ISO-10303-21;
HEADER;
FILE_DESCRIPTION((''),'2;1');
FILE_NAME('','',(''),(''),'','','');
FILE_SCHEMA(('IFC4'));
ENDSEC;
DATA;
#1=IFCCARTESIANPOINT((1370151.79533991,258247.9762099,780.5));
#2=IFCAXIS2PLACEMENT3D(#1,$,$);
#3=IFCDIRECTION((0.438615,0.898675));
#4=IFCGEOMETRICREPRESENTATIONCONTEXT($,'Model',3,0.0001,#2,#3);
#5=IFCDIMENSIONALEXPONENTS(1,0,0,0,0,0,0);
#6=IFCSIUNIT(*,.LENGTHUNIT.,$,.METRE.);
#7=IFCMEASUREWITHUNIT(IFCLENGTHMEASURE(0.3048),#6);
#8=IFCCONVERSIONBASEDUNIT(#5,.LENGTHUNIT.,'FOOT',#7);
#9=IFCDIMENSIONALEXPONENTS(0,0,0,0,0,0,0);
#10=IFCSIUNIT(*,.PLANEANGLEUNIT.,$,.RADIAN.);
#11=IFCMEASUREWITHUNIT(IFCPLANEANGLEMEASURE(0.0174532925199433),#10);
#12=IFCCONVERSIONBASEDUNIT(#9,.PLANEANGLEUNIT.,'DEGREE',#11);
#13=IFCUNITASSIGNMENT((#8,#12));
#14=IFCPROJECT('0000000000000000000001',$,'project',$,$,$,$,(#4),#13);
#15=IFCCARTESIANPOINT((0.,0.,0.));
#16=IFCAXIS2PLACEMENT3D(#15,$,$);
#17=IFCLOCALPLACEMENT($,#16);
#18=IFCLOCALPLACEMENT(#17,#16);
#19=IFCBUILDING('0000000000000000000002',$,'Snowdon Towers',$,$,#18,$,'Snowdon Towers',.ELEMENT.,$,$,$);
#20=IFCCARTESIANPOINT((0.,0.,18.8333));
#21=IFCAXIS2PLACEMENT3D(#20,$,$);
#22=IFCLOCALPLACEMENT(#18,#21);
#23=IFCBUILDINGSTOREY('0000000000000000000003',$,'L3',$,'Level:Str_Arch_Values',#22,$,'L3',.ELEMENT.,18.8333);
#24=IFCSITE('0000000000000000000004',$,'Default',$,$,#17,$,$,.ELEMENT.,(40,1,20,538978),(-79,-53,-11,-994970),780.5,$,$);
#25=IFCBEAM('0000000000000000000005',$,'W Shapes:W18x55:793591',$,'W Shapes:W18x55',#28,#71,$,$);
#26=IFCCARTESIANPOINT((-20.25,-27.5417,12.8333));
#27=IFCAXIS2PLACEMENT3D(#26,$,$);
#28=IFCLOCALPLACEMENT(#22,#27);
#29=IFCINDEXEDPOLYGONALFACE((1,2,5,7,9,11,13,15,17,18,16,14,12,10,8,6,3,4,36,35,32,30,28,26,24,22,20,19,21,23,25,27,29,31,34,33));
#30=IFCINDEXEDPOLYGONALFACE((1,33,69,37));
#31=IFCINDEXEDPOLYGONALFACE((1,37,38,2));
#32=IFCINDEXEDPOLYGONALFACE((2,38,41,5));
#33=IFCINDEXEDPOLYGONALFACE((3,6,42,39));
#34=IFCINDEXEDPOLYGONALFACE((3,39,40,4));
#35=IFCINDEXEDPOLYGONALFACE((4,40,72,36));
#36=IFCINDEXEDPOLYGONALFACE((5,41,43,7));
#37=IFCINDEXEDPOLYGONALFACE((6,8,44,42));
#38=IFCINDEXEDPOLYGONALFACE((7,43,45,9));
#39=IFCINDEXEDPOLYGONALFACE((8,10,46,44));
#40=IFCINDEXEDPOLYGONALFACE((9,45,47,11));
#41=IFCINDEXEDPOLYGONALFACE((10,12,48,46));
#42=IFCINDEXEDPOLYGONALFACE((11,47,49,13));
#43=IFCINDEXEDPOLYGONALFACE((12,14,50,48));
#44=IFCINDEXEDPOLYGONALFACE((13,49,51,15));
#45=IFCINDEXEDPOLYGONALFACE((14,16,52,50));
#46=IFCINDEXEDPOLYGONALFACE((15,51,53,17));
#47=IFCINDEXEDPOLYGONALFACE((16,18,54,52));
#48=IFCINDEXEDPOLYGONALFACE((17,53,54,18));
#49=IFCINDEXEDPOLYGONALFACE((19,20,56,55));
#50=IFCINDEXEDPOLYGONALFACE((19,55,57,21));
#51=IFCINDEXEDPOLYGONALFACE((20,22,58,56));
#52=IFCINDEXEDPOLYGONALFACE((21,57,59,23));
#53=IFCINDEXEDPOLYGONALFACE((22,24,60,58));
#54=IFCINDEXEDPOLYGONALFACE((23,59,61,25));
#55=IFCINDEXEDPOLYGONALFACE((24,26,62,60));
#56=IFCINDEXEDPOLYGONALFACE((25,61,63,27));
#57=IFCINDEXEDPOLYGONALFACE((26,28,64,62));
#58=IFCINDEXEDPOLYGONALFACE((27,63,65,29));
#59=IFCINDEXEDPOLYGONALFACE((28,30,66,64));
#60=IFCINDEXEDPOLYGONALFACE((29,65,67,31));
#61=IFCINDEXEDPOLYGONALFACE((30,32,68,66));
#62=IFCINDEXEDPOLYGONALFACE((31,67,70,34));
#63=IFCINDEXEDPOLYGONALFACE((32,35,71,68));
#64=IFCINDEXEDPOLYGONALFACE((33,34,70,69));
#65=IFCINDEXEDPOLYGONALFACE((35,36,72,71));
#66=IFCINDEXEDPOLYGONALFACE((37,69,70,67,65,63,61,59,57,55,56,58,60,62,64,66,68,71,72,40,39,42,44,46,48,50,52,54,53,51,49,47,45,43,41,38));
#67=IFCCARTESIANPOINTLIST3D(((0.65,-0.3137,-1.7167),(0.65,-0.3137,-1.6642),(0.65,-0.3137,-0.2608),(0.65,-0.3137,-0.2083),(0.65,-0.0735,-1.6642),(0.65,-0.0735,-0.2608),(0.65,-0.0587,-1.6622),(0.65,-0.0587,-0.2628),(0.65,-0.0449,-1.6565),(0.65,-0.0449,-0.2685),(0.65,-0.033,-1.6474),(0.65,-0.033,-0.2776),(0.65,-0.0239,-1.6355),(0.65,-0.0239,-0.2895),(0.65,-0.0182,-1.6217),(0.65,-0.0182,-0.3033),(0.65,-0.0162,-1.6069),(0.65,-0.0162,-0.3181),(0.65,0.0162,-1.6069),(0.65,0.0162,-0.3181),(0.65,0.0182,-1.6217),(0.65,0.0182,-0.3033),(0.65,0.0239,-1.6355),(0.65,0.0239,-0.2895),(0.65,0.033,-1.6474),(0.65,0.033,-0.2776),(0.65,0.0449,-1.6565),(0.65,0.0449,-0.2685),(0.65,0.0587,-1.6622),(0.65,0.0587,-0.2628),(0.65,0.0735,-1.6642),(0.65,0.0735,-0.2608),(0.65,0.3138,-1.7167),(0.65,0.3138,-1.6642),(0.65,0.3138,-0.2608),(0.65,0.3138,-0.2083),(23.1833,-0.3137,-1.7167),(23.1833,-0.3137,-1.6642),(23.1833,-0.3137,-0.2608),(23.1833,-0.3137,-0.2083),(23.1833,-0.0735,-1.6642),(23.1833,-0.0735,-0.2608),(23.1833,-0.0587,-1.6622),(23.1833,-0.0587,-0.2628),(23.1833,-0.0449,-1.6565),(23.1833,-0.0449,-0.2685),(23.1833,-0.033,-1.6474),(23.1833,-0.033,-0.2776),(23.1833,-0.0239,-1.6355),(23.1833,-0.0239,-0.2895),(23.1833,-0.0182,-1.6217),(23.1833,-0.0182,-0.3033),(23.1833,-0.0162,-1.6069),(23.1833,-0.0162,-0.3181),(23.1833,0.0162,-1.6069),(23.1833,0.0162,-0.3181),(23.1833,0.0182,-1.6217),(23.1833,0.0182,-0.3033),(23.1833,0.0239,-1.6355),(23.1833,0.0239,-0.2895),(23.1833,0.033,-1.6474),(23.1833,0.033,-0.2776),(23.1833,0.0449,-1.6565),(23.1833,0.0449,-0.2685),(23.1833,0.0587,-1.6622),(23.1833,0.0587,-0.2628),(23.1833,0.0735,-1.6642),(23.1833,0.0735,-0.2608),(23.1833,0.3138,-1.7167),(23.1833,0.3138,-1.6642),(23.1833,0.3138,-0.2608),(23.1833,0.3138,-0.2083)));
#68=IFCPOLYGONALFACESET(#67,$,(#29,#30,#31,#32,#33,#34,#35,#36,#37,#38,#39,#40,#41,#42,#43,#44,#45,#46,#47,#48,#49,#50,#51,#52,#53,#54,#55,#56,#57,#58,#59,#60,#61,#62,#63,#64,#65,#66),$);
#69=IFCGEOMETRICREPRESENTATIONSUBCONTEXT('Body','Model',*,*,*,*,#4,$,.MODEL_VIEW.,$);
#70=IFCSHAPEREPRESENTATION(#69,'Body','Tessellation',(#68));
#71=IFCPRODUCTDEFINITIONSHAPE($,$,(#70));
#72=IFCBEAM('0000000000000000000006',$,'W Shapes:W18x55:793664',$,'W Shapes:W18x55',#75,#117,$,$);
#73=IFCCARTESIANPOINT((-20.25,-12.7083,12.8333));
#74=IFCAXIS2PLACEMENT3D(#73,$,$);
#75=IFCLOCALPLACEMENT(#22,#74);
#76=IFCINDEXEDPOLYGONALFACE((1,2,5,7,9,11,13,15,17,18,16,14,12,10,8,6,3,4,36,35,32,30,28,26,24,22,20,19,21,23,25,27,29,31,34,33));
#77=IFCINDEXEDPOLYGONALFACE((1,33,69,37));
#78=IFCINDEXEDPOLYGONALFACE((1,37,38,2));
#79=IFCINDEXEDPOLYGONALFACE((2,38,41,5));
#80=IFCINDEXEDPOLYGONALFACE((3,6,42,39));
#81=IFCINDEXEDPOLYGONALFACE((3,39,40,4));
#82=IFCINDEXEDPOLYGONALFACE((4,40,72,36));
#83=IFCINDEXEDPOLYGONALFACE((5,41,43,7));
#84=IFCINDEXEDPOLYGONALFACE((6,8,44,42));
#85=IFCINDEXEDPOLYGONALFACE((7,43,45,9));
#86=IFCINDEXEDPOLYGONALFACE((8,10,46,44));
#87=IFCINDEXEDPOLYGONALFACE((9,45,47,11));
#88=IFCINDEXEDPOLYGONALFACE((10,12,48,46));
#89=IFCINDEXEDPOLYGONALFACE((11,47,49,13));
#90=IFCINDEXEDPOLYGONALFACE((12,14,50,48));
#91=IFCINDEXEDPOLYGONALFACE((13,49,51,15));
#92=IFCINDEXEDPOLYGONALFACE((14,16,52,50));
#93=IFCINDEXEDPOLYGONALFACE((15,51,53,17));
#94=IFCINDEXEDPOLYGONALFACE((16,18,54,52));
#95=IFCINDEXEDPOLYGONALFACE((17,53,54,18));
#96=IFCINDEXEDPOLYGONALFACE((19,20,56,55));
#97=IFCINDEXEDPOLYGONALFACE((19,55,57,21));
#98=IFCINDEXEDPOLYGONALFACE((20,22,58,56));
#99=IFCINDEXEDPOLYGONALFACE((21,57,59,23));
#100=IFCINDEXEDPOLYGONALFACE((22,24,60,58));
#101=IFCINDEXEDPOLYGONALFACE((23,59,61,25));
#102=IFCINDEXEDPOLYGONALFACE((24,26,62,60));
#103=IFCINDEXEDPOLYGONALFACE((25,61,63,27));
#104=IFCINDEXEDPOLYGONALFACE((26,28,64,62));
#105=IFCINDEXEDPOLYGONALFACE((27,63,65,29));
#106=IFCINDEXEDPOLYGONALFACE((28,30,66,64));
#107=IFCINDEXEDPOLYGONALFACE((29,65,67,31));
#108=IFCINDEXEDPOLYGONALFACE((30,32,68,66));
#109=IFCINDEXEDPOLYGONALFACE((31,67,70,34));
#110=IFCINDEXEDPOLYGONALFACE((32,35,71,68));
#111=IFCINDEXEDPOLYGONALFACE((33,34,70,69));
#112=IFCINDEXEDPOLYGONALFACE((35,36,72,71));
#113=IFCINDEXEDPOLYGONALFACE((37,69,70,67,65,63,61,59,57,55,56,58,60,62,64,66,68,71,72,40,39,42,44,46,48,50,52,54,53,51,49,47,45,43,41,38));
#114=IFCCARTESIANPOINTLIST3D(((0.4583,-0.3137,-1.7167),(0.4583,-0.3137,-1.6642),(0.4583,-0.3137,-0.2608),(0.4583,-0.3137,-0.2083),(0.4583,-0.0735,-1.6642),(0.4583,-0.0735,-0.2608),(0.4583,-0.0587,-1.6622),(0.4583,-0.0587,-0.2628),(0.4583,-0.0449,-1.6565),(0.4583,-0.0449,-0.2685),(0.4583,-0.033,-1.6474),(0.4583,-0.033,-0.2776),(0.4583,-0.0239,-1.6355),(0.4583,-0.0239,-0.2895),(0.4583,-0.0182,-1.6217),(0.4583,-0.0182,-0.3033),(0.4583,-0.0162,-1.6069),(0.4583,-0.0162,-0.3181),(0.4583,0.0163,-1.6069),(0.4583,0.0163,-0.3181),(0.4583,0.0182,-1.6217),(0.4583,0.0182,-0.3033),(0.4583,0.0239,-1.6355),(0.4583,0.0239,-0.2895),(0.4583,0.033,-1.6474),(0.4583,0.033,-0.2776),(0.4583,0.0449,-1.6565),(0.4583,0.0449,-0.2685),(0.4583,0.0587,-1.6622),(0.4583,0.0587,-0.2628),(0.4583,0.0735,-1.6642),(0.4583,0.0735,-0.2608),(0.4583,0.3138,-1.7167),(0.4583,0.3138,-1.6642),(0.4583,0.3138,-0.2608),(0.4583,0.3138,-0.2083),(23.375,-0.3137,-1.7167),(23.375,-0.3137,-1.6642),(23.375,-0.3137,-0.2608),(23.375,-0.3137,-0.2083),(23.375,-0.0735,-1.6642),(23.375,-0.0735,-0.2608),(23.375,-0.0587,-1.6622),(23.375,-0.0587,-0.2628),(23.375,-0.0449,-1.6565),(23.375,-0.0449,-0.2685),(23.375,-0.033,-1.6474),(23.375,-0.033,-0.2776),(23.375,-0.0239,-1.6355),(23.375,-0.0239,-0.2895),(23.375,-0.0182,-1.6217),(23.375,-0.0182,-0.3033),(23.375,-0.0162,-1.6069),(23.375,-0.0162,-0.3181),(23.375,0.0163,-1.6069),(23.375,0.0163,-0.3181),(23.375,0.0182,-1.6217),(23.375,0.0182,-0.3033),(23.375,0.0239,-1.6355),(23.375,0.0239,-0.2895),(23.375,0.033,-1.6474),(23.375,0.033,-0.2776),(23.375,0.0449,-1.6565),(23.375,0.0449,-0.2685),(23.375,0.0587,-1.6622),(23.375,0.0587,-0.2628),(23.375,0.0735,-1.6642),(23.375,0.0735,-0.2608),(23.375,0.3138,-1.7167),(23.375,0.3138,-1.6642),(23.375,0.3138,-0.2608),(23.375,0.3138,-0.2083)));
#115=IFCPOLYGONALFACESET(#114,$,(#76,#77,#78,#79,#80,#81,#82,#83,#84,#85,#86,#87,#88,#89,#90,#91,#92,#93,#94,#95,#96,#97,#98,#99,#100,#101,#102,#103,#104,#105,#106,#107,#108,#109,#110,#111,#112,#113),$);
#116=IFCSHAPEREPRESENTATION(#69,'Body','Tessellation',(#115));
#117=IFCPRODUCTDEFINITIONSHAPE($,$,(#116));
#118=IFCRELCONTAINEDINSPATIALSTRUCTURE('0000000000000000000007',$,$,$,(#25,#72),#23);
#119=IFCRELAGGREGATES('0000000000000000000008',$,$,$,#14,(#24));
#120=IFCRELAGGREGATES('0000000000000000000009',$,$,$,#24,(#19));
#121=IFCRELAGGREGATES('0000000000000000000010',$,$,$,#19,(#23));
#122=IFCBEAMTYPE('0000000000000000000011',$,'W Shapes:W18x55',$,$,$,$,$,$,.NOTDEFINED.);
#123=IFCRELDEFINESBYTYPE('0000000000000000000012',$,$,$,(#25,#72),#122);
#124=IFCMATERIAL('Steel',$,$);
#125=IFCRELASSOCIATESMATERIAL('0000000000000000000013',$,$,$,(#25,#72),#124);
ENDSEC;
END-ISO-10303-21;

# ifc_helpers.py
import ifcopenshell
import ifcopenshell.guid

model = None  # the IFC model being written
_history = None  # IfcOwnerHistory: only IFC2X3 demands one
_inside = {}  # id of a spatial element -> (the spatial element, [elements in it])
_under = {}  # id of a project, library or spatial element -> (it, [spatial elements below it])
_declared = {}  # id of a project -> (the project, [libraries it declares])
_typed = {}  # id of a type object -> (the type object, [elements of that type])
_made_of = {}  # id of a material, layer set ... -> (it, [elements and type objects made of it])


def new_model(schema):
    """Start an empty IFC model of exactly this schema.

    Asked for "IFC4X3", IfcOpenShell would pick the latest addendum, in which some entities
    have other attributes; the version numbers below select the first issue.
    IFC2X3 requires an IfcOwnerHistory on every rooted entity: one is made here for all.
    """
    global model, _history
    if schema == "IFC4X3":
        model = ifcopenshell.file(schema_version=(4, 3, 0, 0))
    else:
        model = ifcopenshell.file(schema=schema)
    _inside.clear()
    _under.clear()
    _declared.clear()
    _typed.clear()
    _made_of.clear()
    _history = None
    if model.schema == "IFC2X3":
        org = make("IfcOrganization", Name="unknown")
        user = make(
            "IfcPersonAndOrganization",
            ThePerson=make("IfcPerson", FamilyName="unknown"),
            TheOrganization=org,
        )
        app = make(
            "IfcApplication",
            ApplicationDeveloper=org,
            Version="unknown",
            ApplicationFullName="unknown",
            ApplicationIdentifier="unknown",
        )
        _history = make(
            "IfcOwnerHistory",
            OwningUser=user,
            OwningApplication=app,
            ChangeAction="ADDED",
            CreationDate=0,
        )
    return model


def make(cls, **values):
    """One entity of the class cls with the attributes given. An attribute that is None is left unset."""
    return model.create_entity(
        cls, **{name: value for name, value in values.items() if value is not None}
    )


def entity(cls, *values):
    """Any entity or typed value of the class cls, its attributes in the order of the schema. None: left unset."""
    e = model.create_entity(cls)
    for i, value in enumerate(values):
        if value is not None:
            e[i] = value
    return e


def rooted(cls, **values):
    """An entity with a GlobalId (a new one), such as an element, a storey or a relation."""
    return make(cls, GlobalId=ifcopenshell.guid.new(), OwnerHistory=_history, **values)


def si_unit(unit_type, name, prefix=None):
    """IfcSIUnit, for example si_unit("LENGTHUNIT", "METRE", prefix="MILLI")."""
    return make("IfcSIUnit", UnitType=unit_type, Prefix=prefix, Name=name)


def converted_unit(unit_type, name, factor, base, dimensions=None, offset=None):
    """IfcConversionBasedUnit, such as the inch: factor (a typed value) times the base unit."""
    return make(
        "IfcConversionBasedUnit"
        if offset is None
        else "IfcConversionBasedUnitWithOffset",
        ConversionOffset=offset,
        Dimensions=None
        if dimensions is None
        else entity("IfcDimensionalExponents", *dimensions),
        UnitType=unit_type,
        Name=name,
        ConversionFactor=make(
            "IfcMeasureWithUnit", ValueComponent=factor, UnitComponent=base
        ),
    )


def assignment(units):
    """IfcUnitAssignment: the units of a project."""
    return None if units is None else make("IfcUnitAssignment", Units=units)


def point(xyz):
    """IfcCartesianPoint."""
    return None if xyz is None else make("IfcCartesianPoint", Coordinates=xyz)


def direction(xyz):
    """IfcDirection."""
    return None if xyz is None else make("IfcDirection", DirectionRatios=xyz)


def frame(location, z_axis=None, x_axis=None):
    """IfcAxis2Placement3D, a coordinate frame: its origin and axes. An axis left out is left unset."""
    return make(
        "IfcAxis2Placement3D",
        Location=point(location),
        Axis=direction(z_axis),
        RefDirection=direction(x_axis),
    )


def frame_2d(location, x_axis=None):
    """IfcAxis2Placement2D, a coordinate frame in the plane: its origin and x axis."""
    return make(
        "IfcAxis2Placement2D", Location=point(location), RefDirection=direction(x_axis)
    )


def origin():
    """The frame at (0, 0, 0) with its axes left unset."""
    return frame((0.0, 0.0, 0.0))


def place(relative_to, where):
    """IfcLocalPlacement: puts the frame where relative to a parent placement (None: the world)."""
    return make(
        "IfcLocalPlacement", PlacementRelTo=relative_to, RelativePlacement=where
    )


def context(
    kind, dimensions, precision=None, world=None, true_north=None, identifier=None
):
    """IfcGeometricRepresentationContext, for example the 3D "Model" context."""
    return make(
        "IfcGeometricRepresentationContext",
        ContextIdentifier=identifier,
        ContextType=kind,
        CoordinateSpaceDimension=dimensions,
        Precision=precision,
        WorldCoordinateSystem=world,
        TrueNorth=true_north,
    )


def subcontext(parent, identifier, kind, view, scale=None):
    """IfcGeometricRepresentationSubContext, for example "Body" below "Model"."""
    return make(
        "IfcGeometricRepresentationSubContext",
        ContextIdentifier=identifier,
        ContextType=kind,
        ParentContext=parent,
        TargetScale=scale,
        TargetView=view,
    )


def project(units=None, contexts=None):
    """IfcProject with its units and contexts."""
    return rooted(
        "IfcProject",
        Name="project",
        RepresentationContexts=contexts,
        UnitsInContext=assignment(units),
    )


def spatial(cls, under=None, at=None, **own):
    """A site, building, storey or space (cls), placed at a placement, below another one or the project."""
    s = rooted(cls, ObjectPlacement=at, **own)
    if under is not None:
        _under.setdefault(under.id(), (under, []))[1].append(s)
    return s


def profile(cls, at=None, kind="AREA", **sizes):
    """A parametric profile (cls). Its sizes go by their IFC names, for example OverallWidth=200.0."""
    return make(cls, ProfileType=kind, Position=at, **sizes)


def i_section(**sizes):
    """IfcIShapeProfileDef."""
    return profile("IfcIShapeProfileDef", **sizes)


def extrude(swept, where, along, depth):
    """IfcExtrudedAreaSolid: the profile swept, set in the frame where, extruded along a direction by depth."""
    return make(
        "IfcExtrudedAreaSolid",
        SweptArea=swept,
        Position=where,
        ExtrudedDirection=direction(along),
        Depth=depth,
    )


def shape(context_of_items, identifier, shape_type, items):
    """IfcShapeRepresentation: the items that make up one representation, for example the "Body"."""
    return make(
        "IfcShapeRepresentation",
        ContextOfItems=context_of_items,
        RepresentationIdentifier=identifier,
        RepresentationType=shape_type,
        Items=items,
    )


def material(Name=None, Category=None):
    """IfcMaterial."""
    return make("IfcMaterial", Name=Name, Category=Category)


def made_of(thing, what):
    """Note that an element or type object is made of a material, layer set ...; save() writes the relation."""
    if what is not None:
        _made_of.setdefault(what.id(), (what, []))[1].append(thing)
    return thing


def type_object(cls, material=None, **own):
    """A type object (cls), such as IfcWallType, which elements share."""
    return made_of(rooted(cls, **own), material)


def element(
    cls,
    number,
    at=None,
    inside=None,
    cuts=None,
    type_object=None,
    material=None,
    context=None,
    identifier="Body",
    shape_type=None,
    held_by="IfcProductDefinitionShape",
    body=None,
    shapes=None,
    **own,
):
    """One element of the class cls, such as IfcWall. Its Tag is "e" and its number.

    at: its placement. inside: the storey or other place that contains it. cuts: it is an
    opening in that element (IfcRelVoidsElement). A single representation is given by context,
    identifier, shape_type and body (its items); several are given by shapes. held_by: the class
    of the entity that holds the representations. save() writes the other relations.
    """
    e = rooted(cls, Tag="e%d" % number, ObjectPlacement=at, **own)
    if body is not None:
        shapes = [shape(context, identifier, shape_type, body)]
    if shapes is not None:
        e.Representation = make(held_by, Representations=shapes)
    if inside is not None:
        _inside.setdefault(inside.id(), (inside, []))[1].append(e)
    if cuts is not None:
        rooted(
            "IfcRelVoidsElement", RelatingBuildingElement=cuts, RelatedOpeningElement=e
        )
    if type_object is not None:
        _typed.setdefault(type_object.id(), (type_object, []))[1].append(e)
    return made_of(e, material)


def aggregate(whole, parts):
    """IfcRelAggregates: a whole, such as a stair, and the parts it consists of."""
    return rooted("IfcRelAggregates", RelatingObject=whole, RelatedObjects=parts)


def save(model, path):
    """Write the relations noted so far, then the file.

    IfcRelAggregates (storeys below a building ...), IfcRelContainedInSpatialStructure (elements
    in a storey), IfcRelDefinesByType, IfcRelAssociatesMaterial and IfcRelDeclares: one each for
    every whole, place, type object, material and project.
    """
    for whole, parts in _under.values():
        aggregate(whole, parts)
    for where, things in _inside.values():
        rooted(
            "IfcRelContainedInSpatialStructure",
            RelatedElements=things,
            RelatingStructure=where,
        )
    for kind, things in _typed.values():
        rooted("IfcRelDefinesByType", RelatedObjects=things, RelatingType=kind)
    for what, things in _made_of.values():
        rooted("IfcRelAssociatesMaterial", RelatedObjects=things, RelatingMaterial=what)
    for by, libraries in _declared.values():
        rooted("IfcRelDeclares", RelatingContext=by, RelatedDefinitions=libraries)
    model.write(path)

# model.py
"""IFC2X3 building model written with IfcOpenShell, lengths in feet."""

from ifc_helpers import new_model, entity, si_unit, converted_unit, direction, frame, frame_2d, origin, place, context, subcontext, project, spatial, i_section, extrude, material, type_object, element, save


model = new_model("IFC2X3")

# Units and contexts
model_context = context("Model", 3, precision=0.0001, world=frame((1370151.79533991, 258247.9762099, 780.5)), true_north=direction((0.438615, 0.898675)))
body_context = subcontext(model_context, "Body", "Model", "MODEL_VIEW")
ifc_project = project(units=[converted_unit("LENGTHUNIT", "FOOT", entity("IfcLengthMeasure", 0.3048), si_unit("LENGTHUNIT", "METRE"), dimensions=[1, 0, 0, 0, 0, 0, 0]), converted_unit("PLANEANGLEUNIT", "DEGREE", entity("IfcPlaneAngleMeasure", 0.0174532925199433), si_unit("PLANEANGLEUNIT", "RADIAN"), dimensions=[0, 0, 0, 0, 0, 0, 0])], contexts=[model_context])

# Site, building, storey
site_placement = place(None, origin())
site = spatial("IfcSite", under=ifc_project, at=site_placement, Name="Default", CompositionType="ELEMENT", RefLatitude=(40, 1, 20, 538978), RefLongitude=(-79, -53, -11, -994970), RefElevation=780.5)
building_placement = place(site_placement, origin())
building = spatial("IfcBuilding", under=site, at=building_placement, Name="Snowdon Towers", LongName="Snowdon Towers", CompositionType="ELEMENT")
storey_placement = place(building_placement, frame((0.0, 0.0, 18.8333)))
storey = spatial("IfcBuildingStorey", under=building, at=storey_placement, Name="L3", ObjectType="Level:Str_Arch_Values", LongName="L3", CompositionType="ELEMENT", Elevation=18.8333)

# Beams
ifc_material_1 = material(Name="Steel")
beam_type = type_object("IfcBeamType", Name="W Shapes:W18x55", PredefinedType="NOTDEFINED")
beam_1_placement = place(storey_placement, frame((-20.25, -27.5417, 12.8333)))
element("IfcBeam", 1, at=beam_1_placement, inside=storey, type_object=beam_type, material=ifc_material_1, Name="W Shapes:W18x55:793591", ObjectType="W Shapes:W18x55", context=body_context, shape_type="SweptSolid", body=[
    extrude(i_section(OverallWidth=0.6275, OverallDepth=1.5083, WebThickness=0.0325, FlangeThickness=0.0525, FilletRadius=0.0573, at=frame_2d((0.0, 0.0), x_axis=(0.0, 1.0))), frame((0.65, 0.0, -0.9625), z_axis=(1.0, 0.0, 0.0), x_axis=(0.0, 0.0, -1.0)), (0.0, 0.0, 1.0), 22.5333),
])
beam_2_placement = place(storey_placement, frame((-20.25, -12.7083, 12.8333)))
element("IfcBeam", 2, at=beam_2_placement, inside=storey, type_object=beam_type, material=ifc_material_1, Name="W Shapes:W18x55:793664", ObjectType="W Shapes:W18x55", context=body_context, shape_type="SweptSolid", body=[
    extrude(i_section(OverallWidth=0.6275, OverallDepth=1.5083, WebThickness=0.0325, FlangeThickness=0.0525, FilletRadius=0.0573, at=frame_2d((0.0, 0.0), x_axis=(0.0, 1.0))), frame((0.4583, 0.0, -0.9625), z_axis=(1.0, 0.0, 0.0), x_axis=(0.0, 0.0, -1.0)), (0.0, 0.0, 1.0), 22.9167),
])

save(model, "model.ifc")
